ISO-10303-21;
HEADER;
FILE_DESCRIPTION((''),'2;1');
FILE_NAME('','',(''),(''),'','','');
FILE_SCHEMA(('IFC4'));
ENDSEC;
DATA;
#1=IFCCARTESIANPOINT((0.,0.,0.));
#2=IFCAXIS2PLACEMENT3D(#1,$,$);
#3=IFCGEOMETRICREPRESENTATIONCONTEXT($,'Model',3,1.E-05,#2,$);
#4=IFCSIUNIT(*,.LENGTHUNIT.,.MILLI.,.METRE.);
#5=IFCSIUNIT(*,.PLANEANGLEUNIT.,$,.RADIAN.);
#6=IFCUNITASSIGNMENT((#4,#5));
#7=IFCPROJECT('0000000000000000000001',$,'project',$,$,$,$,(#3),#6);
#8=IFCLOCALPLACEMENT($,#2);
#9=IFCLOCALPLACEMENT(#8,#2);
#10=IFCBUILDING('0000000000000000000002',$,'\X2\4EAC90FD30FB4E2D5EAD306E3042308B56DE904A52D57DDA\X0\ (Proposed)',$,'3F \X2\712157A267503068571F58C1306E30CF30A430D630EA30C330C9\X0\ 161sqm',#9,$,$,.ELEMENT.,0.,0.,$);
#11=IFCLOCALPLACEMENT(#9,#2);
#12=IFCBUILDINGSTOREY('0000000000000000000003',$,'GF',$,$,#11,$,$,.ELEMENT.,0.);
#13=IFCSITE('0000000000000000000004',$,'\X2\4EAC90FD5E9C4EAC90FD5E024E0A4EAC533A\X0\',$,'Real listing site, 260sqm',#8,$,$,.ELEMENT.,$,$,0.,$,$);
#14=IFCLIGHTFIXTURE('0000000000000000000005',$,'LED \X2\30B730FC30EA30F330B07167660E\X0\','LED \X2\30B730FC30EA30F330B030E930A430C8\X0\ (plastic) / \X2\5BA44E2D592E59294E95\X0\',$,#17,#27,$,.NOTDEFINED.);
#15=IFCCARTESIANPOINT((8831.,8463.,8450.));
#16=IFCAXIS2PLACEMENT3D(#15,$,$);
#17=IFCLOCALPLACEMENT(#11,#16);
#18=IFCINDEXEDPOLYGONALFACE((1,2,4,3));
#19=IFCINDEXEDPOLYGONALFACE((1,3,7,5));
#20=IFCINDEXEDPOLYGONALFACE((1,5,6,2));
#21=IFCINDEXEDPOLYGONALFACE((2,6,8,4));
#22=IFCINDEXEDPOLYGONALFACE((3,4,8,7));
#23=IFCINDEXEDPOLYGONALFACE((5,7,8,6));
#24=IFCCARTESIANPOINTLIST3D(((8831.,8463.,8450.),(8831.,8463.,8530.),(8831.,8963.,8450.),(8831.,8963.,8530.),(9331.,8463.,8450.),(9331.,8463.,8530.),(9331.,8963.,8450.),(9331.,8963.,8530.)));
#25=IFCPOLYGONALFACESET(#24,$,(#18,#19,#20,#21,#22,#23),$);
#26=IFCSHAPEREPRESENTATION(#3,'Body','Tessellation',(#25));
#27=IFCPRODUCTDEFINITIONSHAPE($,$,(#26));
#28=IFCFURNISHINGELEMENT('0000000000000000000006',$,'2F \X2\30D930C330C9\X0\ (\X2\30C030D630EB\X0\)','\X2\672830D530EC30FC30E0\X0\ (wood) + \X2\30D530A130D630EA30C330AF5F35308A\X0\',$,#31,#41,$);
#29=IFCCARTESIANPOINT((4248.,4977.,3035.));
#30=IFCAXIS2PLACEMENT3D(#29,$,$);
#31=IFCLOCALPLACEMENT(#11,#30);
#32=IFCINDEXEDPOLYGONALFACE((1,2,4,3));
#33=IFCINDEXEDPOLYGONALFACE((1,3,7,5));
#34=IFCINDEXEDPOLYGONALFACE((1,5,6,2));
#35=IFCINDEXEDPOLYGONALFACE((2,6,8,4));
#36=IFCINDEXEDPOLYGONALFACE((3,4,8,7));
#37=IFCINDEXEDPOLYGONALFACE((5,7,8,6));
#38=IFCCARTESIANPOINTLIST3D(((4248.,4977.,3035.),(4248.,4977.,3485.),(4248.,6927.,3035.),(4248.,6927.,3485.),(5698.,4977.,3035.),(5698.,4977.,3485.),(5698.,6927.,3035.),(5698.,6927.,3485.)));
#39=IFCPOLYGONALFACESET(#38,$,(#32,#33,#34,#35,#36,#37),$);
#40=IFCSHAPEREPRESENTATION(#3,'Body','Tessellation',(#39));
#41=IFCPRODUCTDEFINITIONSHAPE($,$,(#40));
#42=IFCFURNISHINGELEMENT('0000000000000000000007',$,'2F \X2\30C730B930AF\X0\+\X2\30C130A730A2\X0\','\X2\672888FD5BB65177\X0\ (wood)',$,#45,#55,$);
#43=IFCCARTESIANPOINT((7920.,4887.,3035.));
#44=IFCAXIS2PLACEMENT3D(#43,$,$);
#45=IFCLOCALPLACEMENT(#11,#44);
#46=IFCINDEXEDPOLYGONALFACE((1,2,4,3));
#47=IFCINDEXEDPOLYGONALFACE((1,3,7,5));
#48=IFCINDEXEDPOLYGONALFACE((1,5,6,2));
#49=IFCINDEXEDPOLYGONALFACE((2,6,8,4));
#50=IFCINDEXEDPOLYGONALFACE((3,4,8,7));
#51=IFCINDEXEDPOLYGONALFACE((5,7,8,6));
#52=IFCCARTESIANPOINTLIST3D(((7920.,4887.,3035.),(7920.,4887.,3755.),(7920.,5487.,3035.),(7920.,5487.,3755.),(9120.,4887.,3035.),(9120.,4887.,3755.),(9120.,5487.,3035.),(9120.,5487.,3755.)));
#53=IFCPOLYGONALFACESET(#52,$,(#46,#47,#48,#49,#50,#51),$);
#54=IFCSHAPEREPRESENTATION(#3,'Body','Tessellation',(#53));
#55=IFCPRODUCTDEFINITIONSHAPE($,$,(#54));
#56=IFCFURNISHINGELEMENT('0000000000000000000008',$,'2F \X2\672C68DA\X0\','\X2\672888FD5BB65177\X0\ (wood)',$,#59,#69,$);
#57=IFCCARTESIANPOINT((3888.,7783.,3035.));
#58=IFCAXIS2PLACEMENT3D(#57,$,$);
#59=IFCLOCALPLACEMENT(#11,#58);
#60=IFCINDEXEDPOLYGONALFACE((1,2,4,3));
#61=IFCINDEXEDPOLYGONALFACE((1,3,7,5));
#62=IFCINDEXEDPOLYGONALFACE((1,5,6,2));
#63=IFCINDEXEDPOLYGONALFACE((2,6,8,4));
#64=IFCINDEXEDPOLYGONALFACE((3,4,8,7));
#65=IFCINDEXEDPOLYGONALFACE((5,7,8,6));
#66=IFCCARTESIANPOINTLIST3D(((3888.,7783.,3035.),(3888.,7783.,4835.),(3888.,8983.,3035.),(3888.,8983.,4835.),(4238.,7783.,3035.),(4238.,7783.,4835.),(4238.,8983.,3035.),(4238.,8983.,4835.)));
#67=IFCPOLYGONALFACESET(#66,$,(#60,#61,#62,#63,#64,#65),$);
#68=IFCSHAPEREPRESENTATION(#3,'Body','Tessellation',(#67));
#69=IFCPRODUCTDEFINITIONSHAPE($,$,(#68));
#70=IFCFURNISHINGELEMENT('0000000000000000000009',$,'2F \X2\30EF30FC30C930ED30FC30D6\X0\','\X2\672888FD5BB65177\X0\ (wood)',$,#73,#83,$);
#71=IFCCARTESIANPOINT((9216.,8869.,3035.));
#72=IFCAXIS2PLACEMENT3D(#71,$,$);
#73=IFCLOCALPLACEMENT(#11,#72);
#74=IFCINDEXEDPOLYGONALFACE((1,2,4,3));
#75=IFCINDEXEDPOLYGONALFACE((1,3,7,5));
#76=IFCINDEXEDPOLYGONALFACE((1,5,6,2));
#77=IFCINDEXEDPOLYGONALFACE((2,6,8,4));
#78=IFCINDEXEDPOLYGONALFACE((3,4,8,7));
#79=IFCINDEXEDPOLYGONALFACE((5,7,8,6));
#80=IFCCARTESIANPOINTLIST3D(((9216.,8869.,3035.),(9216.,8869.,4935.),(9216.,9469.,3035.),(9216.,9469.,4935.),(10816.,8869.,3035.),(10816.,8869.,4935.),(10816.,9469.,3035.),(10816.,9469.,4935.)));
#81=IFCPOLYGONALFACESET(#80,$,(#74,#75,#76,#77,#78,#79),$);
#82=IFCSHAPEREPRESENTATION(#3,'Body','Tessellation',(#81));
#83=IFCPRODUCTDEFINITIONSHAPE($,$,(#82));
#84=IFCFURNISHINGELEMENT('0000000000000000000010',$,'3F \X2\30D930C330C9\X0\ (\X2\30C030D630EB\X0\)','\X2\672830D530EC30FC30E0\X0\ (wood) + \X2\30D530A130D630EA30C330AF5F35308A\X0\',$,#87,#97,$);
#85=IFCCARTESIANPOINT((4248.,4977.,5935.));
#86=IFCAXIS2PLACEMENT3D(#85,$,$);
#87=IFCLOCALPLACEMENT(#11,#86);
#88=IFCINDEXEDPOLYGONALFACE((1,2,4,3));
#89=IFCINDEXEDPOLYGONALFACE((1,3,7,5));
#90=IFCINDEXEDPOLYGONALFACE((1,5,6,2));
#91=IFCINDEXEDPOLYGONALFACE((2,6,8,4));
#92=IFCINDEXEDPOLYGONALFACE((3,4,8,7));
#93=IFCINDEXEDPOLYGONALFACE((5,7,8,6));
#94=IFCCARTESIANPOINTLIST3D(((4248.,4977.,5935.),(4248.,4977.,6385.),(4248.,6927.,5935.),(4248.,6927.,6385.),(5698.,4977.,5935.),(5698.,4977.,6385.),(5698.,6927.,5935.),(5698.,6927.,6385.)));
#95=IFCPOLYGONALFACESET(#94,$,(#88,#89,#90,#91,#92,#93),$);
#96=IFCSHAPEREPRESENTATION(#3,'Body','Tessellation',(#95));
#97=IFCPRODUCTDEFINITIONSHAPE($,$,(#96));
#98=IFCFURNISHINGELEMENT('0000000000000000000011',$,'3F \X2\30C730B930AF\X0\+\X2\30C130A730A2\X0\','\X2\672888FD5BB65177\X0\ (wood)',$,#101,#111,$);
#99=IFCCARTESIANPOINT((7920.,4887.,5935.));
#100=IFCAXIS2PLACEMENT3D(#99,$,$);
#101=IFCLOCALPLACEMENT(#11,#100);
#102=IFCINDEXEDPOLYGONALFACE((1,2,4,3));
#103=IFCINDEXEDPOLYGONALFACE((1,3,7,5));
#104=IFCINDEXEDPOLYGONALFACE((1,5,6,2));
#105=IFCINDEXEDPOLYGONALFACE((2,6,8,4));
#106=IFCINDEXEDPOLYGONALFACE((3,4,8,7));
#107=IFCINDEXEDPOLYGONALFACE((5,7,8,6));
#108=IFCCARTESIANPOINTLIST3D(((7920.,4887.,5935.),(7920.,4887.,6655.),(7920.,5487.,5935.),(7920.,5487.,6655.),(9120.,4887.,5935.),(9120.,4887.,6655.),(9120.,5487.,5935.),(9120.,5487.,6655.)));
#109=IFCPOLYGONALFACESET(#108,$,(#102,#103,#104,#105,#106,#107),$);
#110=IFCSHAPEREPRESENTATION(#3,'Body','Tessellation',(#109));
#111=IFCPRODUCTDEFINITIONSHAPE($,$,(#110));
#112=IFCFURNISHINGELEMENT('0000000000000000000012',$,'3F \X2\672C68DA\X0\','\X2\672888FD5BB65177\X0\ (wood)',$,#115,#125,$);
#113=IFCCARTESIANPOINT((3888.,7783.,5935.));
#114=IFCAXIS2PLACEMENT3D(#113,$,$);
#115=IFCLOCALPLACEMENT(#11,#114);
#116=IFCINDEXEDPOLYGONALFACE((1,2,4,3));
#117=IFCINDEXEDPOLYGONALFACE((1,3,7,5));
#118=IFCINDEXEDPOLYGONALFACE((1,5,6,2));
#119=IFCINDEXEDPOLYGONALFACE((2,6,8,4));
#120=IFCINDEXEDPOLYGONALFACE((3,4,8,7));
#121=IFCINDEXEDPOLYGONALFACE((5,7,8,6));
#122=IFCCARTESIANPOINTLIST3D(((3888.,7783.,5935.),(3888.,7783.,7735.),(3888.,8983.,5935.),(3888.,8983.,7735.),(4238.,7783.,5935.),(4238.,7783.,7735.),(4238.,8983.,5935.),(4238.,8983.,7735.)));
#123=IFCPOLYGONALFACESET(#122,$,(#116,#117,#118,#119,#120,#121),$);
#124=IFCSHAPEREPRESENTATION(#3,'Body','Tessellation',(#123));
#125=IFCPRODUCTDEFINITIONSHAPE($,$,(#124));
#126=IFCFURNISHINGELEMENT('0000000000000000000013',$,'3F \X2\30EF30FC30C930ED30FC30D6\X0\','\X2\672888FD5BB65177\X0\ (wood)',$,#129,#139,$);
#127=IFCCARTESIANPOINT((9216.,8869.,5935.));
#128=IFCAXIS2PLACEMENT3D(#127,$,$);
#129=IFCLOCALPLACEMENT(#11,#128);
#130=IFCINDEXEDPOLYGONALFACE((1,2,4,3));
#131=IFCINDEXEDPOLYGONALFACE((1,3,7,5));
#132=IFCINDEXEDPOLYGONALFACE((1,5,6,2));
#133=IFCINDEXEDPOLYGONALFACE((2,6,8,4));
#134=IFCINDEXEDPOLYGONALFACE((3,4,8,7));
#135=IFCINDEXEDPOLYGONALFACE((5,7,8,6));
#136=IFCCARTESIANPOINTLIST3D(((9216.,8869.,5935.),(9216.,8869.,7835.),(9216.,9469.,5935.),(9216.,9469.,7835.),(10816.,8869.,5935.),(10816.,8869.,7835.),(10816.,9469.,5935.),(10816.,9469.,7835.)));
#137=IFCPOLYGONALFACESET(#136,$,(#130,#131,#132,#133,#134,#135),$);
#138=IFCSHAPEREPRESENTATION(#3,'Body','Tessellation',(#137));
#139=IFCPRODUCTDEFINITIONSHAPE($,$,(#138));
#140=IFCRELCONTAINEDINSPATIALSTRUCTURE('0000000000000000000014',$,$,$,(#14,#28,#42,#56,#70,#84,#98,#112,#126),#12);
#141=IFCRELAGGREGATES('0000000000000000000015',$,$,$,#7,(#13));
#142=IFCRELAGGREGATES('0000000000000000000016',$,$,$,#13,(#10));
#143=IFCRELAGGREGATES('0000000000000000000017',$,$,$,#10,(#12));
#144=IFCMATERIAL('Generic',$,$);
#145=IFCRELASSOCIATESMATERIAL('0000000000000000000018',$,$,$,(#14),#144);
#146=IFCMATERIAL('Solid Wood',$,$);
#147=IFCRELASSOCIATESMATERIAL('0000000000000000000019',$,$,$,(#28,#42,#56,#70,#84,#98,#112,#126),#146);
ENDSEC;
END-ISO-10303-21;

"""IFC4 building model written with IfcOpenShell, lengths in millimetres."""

from ifc_helpers import new_model, si_unit, frame, frame_2d, origin, place, context, project, spatial, rectangle, extrude, material, element, save


model = new_model("IFC4")

# Units and contexts
model_context = context("Model", 3, precision=1e-05, world=origin())
ifc_project = project(units=[si_unit("LENGTHUNIT", "METRE", prefix="MILLI"), si_unit("PLANEANGLEUNIT", "RADIAN")], contexts=[model_context])

# Site, building, storey
site_placement = place(None, origin())
site = spatial("IfcSite", under=ifc_project, at=site_placement, Name="京都府京都市上京区", ObjectType="Real listing site, 260sqm", CompositionType="ELEMENT", RefElevation=0.0)
building_placement = place(site_placement, origin())
building = spatial("IfcBuilding", under=site, at=building_placement, Name="京都・中庭のある回遊動線 (Proposed)", ObjectType="3F 無垢材と土壁のハイブリッド 161sqm", CompositionType="ELEMENT", ElevationOfRefHeight=0.0, ElevationOfTerrain=0.0)
storey_placement = place(building_placement, origin())
storey = spatial("IfcBuildingStorey", under=building, at=storey_placement, Name="GF", CompositionType="ELEMENT", Elevation=0.0)

# Shared definitions
ifc_material_1 = material(Name="Solid Wood")

# Shared definitions
ifc_material_2 = material(Name="Generic")

# Light fixture
light_fixture_1_placement = place(storey_placement, frame((8831.0, 8463.0, 8450.0)))
element("IfcLightFixture", 1, at=light_fixture_1_placement, inside=storey, material=ifc_material_2, Name="LED シーリング照明", Description="LED シーリングライト (plastic) / 室中央天井", PredefinedType="NOTDEFINED", context=model_context, shape_type="SweptSolid", body=[
    extrude(rectangle(XDim=500.0, YDim=500.0, at=frame_2d((250.0, 250.0))), frame((8831.0, 8463.0, 8450.0)), (0.0, 0.0, 1.0), 80.0),
])

# Furnishing elements
furnishing_1_placement = place(storey_placement, frame((4248.0, 4977.0, 3035.0)))
element("IfcFurnishingElement", 2, at=furnishing_1_placement, inside=storey, material=ifc_material_1, Name="2F ベッド (ダブル)", Description="木フレーム (wood) + ファブリック張り", context=model_context, shape_type="SweptSolid", body=[
    extrude(rectangle(XDim=1450.0, YDim=1950.0, at=frame_2d((725.0, 975.0))), frame((4248.0, 4977.0, 3035.0)), (0.0, 0.0, 1.0), 450.0),
])
furnishing_2_placement = place(storey_placement, frame((7920.0, 4887.0, 3035.0)))
element("IfcFurnishingElement", 3, at=furnishing_2_placement, inside=storey, material=ifc_material_1, Name="2F デスク+チェア", Description="木製家具 (wood)", context=model_context, shape_type="SweptSolid", body=[
    extrude(rectangle(XDim=1200.0, YDim=600.0, at=frame_2d((600.0, 300.0))), frame((7920.0, 4887.0, 3035.0)), (0.0, 0.0, 1.0), 720.0),
])
furnishing_3_placement = place(storey_placement, frame((3888.0, 7783.0, 3035.0)))
element("IfcFurnishingElement", 4, at=furnishing_3_placement, inside=storey, material=ifc_material_1, Name="2F 本棚", Description="木製家具 (wood)", context=model_context, shape_type="SweptSolid", body=[
    extrude(rectangle(XDim=350.0, YDim=1200.0, at=frame_2d((175.0, 600.0))), frame((3888.0, 7783.0, 3035.0)), (0.0, 0.0, 1.0), 1800.0),
])
furnishing_4_placement = place(storey_placement, frame((9216.0, 8869.0, 3035.0)))
element("IfcFurnishingElement", 5, at=furnishing_4_placement, inside=storey, material=ifc_material_1, Name="2F ワードローブ", Description="木製家具 (wood)", context=model_context, shape_type="SweptSolid", body=[
    extrude(rectangle(XDim=1600.0, YDim=600.0, at=frame_2d((800.0, 300.0))), frame((9216.0, 8869.0, 3035.0)), (0.0, 0.0, 1.0), 1900.0),
])
furnishing_5_placement = place(storey_placement, frame((4248.0, 4977.0, 5935.0)))
element("IfcFurnishingElement", 6, at=furnishing_5_placement, inside=storey, material=ifc_material_1, Name="3F ベッド (ダブル)", Description="木フレーム (wood) + ファブリック張り", context=model_context, shape_type="SweptSolid", body=[
    extrude(rectangle(XDim=1450.0, YDim=1950.0, at=frame_2d((725.0, 975.0))), frame((4248.0, 4977.0, 5935.0)), (0.0, 0.0, 1.0), 450.0),
])
furnishing_6_placement = place(storey_placement, frame((7920.0, 4887.0, 5935.0)))
element("IfcFurnishingElement", 7, at=furnishing_6_placement, inside=storey, material=ifc_material_1, Name="3F デスク+チェア", Description="木製家具 (wood)", context=model_context, shape_type="SweptSolid", body=[
    extrude(rectangle(XDim=1200.0, YDim=600.0, at=frame_2d((600.0, 300.0))), frame((7920.0, 4887.0, 5935.0)), (0.0, 0.0, 1.0), 720.0),
])
furnishing_7_placement = place(storey_placement, frame((3888.0, 7783.0, 5935.0)))
element("IfcFurnishingElement", 8, at=furnishing_7_placement, inside=storey, material=ifc_material_1, Name="3F 本棚", Description="木製家具 (wood)", context=model_context, shape_type="SweptSolid", body=[
    extrude(rectangle(XDim=350.0, YDim=1200.0, at=frame_2d((175.0, 600.0))), frame((3888.0, 7783.0, 5935.0)), (0.0, 0.0, 1.0), 1800.0),
])
furnishing_8_placement = place(storey_placement, frame((9216.0, 8869.0, 5935.0)))
element("IfcFurnishingElement", 9, at=furnishing_8_placement, inside=storey, material=ifc_material_1, Name="3F ワードローブ", Description="木製家具 (wood)", context=model_context, shape_type="SweptSolid", body=[
    extrude(rectangle(XDim=1600.0, YDim=600.0, at=frame_2d((800.0, 300.0))), frame((9216.0, 8869.0, 5935.0)), (0.0, 0.0, 1.0), 1900.0),
])

save(model, "model.ifc")
